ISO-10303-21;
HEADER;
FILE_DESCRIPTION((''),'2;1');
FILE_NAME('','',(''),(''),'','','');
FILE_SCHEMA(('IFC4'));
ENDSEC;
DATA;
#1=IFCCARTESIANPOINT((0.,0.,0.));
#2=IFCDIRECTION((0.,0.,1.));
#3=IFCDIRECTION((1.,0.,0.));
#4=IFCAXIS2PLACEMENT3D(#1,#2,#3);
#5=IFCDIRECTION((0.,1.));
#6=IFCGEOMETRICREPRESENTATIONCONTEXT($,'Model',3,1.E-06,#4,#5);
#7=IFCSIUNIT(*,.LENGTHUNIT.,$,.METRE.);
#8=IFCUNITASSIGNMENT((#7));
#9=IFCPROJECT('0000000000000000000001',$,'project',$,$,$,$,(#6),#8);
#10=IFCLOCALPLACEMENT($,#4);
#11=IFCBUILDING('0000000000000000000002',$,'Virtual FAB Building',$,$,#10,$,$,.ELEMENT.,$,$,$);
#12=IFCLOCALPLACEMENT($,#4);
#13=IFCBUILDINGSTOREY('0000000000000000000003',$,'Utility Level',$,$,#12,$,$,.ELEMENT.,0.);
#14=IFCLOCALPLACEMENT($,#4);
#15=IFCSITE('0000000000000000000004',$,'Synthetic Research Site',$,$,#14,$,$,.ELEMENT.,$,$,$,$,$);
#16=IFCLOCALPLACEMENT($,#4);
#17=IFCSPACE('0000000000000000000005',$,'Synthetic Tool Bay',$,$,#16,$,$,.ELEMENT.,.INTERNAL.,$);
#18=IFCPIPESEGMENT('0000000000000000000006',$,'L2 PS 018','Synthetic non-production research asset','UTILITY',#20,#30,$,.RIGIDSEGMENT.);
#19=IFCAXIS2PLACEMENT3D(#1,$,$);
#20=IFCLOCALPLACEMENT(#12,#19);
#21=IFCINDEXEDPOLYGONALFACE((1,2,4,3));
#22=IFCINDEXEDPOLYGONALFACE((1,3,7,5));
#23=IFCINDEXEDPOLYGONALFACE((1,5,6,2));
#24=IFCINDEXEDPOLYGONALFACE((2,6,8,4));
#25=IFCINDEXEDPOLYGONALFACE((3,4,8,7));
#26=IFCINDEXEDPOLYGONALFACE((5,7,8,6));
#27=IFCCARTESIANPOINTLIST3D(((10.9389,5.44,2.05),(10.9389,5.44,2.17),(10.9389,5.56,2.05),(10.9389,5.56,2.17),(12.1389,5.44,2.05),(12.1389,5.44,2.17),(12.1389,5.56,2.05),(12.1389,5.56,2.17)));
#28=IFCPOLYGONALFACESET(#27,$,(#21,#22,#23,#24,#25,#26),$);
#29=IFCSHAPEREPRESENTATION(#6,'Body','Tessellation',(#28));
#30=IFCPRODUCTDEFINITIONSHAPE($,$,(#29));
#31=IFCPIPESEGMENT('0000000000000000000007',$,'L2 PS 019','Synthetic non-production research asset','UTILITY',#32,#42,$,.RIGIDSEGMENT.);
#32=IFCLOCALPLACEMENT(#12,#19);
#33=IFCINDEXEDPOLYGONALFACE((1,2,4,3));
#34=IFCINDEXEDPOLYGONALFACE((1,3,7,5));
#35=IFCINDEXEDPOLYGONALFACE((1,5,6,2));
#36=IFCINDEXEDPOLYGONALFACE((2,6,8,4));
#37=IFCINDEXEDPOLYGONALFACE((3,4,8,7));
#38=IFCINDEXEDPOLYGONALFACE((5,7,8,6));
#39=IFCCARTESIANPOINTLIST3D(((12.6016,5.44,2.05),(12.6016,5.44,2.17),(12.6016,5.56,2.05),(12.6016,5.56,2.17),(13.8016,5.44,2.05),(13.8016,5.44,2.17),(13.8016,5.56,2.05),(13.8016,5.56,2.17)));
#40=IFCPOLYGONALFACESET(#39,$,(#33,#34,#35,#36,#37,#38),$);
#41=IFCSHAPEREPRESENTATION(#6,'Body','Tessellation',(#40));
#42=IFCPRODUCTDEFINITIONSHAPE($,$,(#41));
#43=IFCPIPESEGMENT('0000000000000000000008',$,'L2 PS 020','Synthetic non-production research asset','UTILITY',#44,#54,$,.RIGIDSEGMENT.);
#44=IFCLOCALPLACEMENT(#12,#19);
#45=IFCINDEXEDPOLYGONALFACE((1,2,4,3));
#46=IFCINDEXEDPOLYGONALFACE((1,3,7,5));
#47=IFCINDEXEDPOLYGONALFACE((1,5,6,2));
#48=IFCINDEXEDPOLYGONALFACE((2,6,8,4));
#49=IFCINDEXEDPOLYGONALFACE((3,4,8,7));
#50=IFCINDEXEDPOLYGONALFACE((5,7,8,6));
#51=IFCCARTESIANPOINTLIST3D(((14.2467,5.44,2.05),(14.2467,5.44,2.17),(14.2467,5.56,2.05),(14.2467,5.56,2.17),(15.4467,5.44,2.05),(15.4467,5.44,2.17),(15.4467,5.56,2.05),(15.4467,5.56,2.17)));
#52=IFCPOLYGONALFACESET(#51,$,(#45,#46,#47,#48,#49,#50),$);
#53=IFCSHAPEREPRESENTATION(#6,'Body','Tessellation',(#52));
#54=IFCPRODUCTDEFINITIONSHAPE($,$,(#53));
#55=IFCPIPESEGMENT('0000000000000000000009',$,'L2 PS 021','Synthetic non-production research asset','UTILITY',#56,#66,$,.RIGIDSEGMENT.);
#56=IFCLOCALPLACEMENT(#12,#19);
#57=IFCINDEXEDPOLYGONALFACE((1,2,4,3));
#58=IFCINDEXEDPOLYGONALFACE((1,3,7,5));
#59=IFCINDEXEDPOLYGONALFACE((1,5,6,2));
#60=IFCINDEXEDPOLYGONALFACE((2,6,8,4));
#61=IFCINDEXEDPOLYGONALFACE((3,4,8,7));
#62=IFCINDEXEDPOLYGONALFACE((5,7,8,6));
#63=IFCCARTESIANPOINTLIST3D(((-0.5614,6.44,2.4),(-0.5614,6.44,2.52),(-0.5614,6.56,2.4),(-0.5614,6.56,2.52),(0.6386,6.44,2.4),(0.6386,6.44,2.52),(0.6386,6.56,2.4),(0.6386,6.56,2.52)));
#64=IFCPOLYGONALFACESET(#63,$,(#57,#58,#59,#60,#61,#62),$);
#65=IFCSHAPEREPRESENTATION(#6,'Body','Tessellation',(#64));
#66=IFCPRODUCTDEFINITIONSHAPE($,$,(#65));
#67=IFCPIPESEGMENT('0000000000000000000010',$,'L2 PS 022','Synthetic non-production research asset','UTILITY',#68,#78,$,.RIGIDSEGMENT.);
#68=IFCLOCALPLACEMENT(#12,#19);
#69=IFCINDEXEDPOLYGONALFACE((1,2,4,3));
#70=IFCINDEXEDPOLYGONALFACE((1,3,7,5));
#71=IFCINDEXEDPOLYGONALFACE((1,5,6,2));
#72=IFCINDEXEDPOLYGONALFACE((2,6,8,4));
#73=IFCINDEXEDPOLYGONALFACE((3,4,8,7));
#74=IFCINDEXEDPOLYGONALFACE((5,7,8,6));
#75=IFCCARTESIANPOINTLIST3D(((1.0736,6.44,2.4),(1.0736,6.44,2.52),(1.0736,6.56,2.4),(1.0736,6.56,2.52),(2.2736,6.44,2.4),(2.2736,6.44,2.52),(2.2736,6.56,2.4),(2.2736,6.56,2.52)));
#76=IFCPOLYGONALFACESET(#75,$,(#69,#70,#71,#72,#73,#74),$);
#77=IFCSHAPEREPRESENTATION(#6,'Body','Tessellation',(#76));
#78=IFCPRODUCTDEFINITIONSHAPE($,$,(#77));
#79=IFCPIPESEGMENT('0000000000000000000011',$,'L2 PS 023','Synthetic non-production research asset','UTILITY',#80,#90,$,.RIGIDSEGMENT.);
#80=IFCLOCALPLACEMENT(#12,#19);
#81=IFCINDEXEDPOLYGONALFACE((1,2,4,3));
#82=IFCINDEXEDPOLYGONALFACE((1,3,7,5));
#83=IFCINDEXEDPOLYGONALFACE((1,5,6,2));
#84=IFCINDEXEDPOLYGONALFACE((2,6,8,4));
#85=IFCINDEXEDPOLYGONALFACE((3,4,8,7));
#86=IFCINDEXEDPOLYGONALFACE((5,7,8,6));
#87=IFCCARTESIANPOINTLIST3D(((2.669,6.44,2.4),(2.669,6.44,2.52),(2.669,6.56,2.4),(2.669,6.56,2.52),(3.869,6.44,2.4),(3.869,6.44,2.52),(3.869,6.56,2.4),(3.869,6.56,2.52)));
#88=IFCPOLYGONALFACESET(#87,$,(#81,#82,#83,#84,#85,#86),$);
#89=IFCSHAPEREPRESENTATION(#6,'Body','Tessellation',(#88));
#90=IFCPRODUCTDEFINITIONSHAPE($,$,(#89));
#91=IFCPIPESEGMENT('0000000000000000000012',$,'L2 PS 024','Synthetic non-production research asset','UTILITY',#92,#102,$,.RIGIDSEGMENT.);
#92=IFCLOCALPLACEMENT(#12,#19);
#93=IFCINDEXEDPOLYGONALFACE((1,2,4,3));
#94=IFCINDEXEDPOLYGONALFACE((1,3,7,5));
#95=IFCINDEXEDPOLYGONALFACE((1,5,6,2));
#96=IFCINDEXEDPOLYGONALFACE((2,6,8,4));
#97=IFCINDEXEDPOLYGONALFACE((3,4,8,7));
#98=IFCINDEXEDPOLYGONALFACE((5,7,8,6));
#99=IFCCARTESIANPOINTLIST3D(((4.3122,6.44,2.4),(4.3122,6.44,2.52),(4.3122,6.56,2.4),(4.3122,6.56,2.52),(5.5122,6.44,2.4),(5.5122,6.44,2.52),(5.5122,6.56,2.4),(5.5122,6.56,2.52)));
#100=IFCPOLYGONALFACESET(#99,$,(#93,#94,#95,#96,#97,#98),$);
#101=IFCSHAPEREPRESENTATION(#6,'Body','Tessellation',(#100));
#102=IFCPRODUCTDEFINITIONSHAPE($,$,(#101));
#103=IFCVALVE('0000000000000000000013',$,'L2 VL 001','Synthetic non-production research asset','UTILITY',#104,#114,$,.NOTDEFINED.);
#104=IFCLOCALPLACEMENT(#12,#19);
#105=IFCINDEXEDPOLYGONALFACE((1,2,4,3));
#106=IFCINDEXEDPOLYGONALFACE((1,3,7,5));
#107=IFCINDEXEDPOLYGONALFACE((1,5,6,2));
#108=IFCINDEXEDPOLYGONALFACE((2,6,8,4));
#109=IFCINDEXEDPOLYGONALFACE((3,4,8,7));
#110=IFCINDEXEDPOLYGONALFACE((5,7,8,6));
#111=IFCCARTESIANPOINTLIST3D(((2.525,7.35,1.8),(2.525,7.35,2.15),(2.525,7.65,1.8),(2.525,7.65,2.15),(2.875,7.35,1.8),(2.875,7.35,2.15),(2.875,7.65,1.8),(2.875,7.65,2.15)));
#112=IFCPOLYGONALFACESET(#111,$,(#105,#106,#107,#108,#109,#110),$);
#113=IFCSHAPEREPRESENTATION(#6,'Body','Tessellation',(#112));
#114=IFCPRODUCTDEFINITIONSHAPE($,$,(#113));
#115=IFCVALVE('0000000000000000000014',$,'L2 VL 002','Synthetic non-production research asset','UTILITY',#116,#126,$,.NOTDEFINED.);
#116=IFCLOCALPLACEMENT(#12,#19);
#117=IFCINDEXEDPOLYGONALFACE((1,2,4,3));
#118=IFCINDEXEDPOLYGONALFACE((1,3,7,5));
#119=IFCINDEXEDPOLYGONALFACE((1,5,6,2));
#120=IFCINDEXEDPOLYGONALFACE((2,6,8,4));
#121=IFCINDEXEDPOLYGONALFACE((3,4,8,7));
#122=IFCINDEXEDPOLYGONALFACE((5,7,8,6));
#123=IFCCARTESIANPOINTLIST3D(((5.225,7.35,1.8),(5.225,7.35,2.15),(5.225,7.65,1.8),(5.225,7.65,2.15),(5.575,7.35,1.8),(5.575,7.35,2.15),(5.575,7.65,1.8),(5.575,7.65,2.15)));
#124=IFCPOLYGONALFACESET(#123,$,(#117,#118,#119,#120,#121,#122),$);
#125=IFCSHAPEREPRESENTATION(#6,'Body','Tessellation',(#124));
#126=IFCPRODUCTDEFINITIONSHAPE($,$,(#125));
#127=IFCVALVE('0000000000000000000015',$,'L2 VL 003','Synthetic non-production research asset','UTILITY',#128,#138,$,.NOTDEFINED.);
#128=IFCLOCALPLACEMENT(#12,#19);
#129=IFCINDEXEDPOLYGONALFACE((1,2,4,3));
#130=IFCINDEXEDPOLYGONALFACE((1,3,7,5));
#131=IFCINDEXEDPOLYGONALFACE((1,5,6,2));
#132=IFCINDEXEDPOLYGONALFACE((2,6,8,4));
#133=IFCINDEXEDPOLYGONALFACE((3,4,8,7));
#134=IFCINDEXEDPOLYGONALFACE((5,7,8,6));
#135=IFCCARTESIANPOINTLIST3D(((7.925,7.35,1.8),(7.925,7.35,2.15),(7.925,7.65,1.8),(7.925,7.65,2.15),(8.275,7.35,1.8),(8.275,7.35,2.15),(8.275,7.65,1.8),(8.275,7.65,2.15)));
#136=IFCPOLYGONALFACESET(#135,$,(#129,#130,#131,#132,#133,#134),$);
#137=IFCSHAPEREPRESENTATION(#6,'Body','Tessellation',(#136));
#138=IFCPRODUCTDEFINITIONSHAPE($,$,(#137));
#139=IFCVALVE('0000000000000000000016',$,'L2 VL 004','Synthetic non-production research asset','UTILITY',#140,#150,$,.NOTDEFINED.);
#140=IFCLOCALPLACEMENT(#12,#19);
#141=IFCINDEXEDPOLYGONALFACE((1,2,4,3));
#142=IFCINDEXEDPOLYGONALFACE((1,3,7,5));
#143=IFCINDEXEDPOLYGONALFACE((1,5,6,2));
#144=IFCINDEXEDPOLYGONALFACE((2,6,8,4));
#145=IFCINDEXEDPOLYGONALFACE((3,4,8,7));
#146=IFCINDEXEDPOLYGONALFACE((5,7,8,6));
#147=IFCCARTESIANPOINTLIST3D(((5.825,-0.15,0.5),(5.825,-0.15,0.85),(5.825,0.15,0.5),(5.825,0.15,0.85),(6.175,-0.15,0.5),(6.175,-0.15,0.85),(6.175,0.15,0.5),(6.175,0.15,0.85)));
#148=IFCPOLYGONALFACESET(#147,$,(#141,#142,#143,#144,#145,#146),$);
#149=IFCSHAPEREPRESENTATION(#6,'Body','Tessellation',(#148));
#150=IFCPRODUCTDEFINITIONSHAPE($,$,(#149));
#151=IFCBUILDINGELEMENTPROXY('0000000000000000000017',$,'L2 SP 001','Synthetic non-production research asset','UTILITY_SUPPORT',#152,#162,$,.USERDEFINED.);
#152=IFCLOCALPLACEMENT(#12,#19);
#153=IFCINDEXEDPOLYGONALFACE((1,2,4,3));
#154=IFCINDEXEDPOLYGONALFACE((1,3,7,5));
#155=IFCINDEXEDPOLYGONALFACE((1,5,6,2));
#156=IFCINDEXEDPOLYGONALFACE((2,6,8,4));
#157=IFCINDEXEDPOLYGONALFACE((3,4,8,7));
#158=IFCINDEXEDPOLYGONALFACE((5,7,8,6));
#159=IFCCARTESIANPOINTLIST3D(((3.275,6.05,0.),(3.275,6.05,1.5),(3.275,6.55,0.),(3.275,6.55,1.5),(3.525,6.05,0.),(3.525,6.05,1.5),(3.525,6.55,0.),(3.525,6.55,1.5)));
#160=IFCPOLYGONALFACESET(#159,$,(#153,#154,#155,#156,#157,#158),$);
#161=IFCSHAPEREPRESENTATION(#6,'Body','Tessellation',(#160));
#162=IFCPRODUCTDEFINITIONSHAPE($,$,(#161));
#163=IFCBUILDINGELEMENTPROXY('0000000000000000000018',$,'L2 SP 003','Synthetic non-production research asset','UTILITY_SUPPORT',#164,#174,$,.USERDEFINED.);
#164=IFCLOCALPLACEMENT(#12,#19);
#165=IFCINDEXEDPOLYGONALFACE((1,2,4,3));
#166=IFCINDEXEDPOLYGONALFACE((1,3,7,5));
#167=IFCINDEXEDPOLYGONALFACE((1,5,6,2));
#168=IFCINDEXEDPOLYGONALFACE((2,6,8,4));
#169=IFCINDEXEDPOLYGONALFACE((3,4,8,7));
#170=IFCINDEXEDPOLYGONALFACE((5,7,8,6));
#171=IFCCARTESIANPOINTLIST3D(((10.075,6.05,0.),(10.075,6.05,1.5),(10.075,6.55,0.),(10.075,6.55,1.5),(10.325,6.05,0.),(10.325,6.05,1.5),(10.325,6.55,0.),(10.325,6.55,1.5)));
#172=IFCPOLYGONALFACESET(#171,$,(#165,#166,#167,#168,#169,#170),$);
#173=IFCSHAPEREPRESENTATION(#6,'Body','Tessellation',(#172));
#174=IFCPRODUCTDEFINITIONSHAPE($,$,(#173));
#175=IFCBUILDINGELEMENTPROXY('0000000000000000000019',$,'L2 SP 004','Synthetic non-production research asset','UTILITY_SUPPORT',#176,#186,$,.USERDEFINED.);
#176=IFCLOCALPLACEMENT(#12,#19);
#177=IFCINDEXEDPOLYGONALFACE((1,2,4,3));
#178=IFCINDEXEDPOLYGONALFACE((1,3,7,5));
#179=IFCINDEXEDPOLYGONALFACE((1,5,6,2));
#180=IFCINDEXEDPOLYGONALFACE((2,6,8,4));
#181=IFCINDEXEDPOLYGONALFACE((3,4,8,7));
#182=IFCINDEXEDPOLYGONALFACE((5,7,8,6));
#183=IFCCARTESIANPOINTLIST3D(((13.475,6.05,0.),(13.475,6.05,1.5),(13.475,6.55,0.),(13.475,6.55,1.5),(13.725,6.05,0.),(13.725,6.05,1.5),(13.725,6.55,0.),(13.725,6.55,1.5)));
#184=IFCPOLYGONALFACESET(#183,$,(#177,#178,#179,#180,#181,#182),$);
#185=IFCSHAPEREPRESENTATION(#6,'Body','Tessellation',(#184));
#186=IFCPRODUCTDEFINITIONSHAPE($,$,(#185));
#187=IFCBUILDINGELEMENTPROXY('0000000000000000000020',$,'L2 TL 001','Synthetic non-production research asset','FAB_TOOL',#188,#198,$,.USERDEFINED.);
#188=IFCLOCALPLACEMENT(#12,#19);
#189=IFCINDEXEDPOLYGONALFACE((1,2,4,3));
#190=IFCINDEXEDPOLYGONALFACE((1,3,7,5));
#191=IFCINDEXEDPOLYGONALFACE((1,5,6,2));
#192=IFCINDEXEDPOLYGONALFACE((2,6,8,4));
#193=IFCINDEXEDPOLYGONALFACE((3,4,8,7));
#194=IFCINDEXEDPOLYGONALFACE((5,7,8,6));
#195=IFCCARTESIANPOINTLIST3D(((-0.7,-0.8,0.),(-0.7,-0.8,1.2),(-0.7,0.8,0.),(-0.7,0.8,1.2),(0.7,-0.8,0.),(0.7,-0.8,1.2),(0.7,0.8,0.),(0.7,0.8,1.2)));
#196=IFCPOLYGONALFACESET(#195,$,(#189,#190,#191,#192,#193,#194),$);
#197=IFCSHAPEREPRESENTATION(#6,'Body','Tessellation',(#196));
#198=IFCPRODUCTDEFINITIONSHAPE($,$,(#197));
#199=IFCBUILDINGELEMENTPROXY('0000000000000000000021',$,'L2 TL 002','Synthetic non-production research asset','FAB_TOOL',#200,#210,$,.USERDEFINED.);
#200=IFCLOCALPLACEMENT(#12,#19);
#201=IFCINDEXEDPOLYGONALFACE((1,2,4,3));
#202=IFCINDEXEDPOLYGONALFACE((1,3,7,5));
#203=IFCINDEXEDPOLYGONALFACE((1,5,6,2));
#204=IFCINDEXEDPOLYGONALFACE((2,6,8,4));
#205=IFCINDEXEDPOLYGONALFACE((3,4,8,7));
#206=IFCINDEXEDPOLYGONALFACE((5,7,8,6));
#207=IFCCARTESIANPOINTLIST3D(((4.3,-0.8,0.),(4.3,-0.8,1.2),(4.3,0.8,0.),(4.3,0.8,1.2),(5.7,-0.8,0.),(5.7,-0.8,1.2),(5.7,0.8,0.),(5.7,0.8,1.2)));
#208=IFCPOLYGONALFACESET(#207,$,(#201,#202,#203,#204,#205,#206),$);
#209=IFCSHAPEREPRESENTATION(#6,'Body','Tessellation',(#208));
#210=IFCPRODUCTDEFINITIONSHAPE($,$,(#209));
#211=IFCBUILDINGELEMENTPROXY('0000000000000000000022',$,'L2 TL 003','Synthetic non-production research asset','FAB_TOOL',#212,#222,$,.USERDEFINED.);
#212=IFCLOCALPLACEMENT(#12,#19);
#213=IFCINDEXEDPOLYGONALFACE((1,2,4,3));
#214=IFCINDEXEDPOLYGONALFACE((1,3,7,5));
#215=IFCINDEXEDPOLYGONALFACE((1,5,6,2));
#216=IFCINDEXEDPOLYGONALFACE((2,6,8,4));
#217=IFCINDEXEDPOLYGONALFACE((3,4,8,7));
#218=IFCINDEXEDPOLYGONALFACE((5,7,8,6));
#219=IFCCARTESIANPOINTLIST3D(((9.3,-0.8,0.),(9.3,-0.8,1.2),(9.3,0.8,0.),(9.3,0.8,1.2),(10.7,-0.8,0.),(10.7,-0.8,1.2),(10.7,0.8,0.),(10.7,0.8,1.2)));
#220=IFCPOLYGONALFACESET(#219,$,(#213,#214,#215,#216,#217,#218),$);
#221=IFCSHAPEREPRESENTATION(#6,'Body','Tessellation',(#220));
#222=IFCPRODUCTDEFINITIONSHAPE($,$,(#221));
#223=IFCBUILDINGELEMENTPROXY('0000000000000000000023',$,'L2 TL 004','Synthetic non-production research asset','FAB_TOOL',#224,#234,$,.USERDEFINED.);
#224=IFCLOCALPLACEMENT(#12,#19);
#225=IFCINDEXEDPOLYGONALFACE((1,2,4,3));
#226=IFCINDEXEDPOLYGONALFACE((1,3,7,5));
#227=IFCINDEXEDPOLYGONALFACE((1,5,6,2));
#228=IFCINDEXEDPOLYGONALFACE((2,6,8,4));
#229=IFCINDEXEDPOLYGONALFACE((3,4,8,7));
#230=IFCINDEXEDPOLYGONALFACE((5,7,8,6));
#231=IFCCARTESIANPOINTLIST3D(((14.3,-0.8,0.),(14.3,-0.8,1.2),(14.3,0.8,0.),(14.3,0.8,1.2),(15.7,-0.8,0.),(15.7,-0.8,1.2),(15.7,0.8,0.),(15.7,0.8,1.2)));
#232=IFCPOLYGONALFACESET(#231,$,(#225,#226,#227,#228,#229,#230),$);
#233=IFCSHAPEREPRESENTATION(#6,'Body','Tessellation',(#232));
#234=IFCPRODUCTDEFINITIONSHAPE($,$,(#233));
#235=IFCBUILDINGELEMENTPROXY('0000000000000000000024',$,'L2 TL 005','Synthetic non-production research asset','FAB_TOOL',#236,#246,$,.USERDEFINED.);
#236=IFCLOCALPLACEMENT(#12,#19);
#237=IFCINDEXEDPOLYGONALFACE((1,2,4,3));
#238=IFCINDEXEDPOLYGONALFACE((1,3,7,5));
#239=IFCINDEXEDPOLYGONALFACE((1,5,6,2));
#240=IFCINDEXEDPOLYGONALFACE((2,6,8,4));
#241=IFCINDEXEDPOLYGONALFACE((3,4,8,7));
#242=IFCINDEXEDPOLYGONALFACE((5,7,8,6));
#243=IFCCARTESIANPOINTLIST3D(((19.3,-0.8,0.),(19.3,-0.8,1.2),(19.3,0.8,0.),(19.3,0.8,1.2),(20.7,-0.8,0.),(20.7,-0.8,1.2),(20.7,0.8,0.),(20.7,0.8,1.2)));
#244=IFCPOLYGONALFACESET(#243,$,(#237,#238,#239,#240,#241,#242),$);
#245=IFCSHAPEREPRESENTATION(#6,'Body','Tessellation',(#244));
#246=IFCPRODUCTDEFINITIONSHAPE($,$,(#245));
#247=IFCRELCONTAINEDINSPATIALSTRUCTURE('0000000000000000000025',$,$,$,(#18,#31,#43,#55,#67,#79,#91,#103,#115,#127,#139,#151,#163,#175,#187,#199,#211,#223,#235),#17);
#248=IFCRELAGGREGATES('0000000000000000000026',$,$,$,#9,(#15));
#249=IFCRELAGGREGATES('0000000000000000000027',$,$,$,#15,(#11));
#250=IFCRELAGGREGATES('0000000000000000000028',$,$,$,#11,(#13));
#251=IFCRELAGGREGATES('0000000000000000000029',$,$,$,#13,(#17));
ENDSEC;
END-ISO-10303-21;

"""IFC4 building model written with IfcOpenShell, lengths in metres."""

from ifc_helpers import new_model, si_unit, direction, frame, origin_with_axes, origin_2d_with_axis, place, context, project, spatial, rectangle, extrude, element, save


model = new_model("IFC4")

# Units and contexts
model_context = context("Model", 3, precision=1e-06, world=origin_with_axes(), true_north=direction((0.0, 1.0)))
ifc_project = project(units=[si_unit("LENGTHUNIT", "METRE")], contexts=[model_context])

# Site, building, storey, space
site_placement = place(None, origin_with_axes())
site = spatial("IfcSite", under=ifc_project, at=site_placement, Name="Synthetic Research Site", CompositionType="ELEMENT")
building_placement = place(None, origin_with_axes())
building = spatial("IfcBuilding", under=site, at=building_placement, Name="Virtual FAB Building", CompositionType="ELEMENT")
storey_placement = place(None, origin_with_axes())
storey = spatial("IfcBuildingStorey", under=building, at=storey_placement, Name="Utility Level", CompositionType="ELEMENT", Elevation=0.0)
space_placement = place(None, origin_with_axes())
space = spatial("IfcSpace", under=storey, at=space_placement, Name="Synthetic Tool Bay", CompositionType="ELEMENT", PredefinedType="INTERNAL")

# Pipe segments
for number, where, z_axis, x_axis, name in (
    (1, (11.5389, 5.5, 2.05), (0.0, 0.0, 1.0), (1.0, 0.0, 0.0), "L2 PS 018"),
    (2, (13.2016, 5.5, 2.05), (0.0, 0.0, 1.0), (1.0, 0.0, 0.0), "L2 PS 019"),
    (3, (14.8467, 5.5, 2.05), (0.0, 0.0, 1.0), (1.0, 0.0, 0.0), "L2 PS 020"),
    (4, (0.0386, 6.5, 2.4), (0.0, 0.0, 1.0), (1.0, 0.0, 0.0), "L2 PS 021"),
    (5, (1.6736, 6.5, 2.4), (0.0, 0.0, 1.0), (1.0, 0.0, 0.0), "L2 PS 022"),
    (6, (3.269, 6.5, 2.4), (0.0, 0.0, 1.0), (1.0, 0.0, 0.0), "L2 PS 023"),
    (7, (4.9122, 6.5, 2.4), (0.0, 0.0, 1.0), (1.0, 0.0, 0.0), "L2 PS 024"),
):
    element("IfcPipeSegment", number, at=place(None, frame(where, z_axis=z_axis, x_axis=x_axis)), inside=space, Name=name, Description="Synthetic non-production research asset", ObjectType="UTILITY", PredefinedType="RIGIDSEGMENT", context=model_context, shape_type="SweptSolid", body=[
        extrude(rectangle(XDim=1.2, YDim=0.12, at=origin_2d_with_axis()), origin_with_axes(), (0.0, 0.0, 1.0), 0.12),
    ])

# Valves
for number, where, z_axis, x_axis, name in (
    (8, (2.7, 7.5, 1.8), (0.0, 0.0, 1.0), (1.0, 0.0, 0.0), "L2 VL 001"),
    (9, (5.4, 7.5, 1.8), (0.0, 0.0, 1.0), (1.0, 0.0, 0.0), "L2 VL 002"),
    (10, (8.1, 7.5, 1.8), (0.0, 0.0, 1.0), (1.0, 0.0, 0.0), "L2 VL 003"),
    (11, (6.0, 0.0, 0.5), (0.0, 0.0, 1.0), (1.0, 0.0, 0.0), "L2 VL 004"),
):
    element("IfcValve", number, at=place(None, frame(where, z_axis=z_axis, x_axis=x_axis)), inside=space, Name=name, Description="Synthetic non-production research asset", ObjectType="UTILITY", PredefinedType="NOTDEFINED", context=model_context, shape_type="SweptSolid", body=[
        extrude(rectangle(XDim=0.35, YDim=0.3, at=origin_2d_with_axis()), origin_with_axes(), (0.0, 0.0, 1.0), 0.35),
    ])

# Building element proxies
for number, where, z_axis, x_axis, name in (
    (12, (3.4, 6.3, 0.0), (0.0, 0.0, 1.0), (1.0, 0.0, 0.0), "L2 SP 001"),
    (13, (10.2, 6.3, 0.0), (0.0, 0.0, 1.0), (1.0, 0.0, 0.0), "L2 SP 003"),
    (14, (13.6, 6.3, 0.0), (0.0, 0.0, 1.0), (1.0, 0.0, 0.0), "L2 SP 004"),
):
    element("IfcBuildingElementProxy", number, at=place(None, frame(where, z_axis=z_axis, x_axis=x_axis)), inside=space, Name=name, Description="Synthetic non-production research asset", ObjectType="UTILITY_SUPPORT", PredefinedType="USERDEFINED", context=model_context, shape_type="SweptSolid", body=[
        extrude(rectangle(XDim=0.25, YDim=0.5, at=origin_2d_with_axis()), origin_with_axes(), (0.0, 0.0, 1.0), 1.5),
    ])
for number, where, z_axis, x_axis, name in (
    (15, (0.0, 0.0, 0.0), (0.0, 0.0, 1.0), (1.0, 0.0, 0.0), "L2 TL 001"),
    (16, (5.0, 0.0, 0.0), (0.0, 0.0, 1.0), (1.0, 0.0, 0.0), "L2 TL 002"),
    (17, (10.0, 0.0, 0.0), (0.0, 0.0, 1.0), (1.0, 0.0, 0.0), "L2 TL 003"),
    (18, (15.0, 0.0, 0.0), (0.0, 0.0, 1.0), (1.0, 0.0, 0.0), "L2 TL 004"),
    (19, (20.0, 0.0, 0.0), (0.0, 0.0, 1.0), (1.0, 0.0, 0.0), "L2 TL 005"),
):
    element("IfcBuildingElementProxy", number, at=place(None, frame(where, z_axis=z_axis, x_axis=x_axis)), inside=space, Name=name, Description="Synthetic non-production research asset", ObjectType="FAB_TOOL", PredefinedType="USERDEFINED", context=model_context, shape_type="SweptSolid", body=[
        extrude(rectangle(XDim=1.4, YDim=1.6, at=origin_2d_with_axis()), origin_with_axes(), (0.0, 0.0, 1.0), 1.2),
    ])

save(model, "model.ifc")
